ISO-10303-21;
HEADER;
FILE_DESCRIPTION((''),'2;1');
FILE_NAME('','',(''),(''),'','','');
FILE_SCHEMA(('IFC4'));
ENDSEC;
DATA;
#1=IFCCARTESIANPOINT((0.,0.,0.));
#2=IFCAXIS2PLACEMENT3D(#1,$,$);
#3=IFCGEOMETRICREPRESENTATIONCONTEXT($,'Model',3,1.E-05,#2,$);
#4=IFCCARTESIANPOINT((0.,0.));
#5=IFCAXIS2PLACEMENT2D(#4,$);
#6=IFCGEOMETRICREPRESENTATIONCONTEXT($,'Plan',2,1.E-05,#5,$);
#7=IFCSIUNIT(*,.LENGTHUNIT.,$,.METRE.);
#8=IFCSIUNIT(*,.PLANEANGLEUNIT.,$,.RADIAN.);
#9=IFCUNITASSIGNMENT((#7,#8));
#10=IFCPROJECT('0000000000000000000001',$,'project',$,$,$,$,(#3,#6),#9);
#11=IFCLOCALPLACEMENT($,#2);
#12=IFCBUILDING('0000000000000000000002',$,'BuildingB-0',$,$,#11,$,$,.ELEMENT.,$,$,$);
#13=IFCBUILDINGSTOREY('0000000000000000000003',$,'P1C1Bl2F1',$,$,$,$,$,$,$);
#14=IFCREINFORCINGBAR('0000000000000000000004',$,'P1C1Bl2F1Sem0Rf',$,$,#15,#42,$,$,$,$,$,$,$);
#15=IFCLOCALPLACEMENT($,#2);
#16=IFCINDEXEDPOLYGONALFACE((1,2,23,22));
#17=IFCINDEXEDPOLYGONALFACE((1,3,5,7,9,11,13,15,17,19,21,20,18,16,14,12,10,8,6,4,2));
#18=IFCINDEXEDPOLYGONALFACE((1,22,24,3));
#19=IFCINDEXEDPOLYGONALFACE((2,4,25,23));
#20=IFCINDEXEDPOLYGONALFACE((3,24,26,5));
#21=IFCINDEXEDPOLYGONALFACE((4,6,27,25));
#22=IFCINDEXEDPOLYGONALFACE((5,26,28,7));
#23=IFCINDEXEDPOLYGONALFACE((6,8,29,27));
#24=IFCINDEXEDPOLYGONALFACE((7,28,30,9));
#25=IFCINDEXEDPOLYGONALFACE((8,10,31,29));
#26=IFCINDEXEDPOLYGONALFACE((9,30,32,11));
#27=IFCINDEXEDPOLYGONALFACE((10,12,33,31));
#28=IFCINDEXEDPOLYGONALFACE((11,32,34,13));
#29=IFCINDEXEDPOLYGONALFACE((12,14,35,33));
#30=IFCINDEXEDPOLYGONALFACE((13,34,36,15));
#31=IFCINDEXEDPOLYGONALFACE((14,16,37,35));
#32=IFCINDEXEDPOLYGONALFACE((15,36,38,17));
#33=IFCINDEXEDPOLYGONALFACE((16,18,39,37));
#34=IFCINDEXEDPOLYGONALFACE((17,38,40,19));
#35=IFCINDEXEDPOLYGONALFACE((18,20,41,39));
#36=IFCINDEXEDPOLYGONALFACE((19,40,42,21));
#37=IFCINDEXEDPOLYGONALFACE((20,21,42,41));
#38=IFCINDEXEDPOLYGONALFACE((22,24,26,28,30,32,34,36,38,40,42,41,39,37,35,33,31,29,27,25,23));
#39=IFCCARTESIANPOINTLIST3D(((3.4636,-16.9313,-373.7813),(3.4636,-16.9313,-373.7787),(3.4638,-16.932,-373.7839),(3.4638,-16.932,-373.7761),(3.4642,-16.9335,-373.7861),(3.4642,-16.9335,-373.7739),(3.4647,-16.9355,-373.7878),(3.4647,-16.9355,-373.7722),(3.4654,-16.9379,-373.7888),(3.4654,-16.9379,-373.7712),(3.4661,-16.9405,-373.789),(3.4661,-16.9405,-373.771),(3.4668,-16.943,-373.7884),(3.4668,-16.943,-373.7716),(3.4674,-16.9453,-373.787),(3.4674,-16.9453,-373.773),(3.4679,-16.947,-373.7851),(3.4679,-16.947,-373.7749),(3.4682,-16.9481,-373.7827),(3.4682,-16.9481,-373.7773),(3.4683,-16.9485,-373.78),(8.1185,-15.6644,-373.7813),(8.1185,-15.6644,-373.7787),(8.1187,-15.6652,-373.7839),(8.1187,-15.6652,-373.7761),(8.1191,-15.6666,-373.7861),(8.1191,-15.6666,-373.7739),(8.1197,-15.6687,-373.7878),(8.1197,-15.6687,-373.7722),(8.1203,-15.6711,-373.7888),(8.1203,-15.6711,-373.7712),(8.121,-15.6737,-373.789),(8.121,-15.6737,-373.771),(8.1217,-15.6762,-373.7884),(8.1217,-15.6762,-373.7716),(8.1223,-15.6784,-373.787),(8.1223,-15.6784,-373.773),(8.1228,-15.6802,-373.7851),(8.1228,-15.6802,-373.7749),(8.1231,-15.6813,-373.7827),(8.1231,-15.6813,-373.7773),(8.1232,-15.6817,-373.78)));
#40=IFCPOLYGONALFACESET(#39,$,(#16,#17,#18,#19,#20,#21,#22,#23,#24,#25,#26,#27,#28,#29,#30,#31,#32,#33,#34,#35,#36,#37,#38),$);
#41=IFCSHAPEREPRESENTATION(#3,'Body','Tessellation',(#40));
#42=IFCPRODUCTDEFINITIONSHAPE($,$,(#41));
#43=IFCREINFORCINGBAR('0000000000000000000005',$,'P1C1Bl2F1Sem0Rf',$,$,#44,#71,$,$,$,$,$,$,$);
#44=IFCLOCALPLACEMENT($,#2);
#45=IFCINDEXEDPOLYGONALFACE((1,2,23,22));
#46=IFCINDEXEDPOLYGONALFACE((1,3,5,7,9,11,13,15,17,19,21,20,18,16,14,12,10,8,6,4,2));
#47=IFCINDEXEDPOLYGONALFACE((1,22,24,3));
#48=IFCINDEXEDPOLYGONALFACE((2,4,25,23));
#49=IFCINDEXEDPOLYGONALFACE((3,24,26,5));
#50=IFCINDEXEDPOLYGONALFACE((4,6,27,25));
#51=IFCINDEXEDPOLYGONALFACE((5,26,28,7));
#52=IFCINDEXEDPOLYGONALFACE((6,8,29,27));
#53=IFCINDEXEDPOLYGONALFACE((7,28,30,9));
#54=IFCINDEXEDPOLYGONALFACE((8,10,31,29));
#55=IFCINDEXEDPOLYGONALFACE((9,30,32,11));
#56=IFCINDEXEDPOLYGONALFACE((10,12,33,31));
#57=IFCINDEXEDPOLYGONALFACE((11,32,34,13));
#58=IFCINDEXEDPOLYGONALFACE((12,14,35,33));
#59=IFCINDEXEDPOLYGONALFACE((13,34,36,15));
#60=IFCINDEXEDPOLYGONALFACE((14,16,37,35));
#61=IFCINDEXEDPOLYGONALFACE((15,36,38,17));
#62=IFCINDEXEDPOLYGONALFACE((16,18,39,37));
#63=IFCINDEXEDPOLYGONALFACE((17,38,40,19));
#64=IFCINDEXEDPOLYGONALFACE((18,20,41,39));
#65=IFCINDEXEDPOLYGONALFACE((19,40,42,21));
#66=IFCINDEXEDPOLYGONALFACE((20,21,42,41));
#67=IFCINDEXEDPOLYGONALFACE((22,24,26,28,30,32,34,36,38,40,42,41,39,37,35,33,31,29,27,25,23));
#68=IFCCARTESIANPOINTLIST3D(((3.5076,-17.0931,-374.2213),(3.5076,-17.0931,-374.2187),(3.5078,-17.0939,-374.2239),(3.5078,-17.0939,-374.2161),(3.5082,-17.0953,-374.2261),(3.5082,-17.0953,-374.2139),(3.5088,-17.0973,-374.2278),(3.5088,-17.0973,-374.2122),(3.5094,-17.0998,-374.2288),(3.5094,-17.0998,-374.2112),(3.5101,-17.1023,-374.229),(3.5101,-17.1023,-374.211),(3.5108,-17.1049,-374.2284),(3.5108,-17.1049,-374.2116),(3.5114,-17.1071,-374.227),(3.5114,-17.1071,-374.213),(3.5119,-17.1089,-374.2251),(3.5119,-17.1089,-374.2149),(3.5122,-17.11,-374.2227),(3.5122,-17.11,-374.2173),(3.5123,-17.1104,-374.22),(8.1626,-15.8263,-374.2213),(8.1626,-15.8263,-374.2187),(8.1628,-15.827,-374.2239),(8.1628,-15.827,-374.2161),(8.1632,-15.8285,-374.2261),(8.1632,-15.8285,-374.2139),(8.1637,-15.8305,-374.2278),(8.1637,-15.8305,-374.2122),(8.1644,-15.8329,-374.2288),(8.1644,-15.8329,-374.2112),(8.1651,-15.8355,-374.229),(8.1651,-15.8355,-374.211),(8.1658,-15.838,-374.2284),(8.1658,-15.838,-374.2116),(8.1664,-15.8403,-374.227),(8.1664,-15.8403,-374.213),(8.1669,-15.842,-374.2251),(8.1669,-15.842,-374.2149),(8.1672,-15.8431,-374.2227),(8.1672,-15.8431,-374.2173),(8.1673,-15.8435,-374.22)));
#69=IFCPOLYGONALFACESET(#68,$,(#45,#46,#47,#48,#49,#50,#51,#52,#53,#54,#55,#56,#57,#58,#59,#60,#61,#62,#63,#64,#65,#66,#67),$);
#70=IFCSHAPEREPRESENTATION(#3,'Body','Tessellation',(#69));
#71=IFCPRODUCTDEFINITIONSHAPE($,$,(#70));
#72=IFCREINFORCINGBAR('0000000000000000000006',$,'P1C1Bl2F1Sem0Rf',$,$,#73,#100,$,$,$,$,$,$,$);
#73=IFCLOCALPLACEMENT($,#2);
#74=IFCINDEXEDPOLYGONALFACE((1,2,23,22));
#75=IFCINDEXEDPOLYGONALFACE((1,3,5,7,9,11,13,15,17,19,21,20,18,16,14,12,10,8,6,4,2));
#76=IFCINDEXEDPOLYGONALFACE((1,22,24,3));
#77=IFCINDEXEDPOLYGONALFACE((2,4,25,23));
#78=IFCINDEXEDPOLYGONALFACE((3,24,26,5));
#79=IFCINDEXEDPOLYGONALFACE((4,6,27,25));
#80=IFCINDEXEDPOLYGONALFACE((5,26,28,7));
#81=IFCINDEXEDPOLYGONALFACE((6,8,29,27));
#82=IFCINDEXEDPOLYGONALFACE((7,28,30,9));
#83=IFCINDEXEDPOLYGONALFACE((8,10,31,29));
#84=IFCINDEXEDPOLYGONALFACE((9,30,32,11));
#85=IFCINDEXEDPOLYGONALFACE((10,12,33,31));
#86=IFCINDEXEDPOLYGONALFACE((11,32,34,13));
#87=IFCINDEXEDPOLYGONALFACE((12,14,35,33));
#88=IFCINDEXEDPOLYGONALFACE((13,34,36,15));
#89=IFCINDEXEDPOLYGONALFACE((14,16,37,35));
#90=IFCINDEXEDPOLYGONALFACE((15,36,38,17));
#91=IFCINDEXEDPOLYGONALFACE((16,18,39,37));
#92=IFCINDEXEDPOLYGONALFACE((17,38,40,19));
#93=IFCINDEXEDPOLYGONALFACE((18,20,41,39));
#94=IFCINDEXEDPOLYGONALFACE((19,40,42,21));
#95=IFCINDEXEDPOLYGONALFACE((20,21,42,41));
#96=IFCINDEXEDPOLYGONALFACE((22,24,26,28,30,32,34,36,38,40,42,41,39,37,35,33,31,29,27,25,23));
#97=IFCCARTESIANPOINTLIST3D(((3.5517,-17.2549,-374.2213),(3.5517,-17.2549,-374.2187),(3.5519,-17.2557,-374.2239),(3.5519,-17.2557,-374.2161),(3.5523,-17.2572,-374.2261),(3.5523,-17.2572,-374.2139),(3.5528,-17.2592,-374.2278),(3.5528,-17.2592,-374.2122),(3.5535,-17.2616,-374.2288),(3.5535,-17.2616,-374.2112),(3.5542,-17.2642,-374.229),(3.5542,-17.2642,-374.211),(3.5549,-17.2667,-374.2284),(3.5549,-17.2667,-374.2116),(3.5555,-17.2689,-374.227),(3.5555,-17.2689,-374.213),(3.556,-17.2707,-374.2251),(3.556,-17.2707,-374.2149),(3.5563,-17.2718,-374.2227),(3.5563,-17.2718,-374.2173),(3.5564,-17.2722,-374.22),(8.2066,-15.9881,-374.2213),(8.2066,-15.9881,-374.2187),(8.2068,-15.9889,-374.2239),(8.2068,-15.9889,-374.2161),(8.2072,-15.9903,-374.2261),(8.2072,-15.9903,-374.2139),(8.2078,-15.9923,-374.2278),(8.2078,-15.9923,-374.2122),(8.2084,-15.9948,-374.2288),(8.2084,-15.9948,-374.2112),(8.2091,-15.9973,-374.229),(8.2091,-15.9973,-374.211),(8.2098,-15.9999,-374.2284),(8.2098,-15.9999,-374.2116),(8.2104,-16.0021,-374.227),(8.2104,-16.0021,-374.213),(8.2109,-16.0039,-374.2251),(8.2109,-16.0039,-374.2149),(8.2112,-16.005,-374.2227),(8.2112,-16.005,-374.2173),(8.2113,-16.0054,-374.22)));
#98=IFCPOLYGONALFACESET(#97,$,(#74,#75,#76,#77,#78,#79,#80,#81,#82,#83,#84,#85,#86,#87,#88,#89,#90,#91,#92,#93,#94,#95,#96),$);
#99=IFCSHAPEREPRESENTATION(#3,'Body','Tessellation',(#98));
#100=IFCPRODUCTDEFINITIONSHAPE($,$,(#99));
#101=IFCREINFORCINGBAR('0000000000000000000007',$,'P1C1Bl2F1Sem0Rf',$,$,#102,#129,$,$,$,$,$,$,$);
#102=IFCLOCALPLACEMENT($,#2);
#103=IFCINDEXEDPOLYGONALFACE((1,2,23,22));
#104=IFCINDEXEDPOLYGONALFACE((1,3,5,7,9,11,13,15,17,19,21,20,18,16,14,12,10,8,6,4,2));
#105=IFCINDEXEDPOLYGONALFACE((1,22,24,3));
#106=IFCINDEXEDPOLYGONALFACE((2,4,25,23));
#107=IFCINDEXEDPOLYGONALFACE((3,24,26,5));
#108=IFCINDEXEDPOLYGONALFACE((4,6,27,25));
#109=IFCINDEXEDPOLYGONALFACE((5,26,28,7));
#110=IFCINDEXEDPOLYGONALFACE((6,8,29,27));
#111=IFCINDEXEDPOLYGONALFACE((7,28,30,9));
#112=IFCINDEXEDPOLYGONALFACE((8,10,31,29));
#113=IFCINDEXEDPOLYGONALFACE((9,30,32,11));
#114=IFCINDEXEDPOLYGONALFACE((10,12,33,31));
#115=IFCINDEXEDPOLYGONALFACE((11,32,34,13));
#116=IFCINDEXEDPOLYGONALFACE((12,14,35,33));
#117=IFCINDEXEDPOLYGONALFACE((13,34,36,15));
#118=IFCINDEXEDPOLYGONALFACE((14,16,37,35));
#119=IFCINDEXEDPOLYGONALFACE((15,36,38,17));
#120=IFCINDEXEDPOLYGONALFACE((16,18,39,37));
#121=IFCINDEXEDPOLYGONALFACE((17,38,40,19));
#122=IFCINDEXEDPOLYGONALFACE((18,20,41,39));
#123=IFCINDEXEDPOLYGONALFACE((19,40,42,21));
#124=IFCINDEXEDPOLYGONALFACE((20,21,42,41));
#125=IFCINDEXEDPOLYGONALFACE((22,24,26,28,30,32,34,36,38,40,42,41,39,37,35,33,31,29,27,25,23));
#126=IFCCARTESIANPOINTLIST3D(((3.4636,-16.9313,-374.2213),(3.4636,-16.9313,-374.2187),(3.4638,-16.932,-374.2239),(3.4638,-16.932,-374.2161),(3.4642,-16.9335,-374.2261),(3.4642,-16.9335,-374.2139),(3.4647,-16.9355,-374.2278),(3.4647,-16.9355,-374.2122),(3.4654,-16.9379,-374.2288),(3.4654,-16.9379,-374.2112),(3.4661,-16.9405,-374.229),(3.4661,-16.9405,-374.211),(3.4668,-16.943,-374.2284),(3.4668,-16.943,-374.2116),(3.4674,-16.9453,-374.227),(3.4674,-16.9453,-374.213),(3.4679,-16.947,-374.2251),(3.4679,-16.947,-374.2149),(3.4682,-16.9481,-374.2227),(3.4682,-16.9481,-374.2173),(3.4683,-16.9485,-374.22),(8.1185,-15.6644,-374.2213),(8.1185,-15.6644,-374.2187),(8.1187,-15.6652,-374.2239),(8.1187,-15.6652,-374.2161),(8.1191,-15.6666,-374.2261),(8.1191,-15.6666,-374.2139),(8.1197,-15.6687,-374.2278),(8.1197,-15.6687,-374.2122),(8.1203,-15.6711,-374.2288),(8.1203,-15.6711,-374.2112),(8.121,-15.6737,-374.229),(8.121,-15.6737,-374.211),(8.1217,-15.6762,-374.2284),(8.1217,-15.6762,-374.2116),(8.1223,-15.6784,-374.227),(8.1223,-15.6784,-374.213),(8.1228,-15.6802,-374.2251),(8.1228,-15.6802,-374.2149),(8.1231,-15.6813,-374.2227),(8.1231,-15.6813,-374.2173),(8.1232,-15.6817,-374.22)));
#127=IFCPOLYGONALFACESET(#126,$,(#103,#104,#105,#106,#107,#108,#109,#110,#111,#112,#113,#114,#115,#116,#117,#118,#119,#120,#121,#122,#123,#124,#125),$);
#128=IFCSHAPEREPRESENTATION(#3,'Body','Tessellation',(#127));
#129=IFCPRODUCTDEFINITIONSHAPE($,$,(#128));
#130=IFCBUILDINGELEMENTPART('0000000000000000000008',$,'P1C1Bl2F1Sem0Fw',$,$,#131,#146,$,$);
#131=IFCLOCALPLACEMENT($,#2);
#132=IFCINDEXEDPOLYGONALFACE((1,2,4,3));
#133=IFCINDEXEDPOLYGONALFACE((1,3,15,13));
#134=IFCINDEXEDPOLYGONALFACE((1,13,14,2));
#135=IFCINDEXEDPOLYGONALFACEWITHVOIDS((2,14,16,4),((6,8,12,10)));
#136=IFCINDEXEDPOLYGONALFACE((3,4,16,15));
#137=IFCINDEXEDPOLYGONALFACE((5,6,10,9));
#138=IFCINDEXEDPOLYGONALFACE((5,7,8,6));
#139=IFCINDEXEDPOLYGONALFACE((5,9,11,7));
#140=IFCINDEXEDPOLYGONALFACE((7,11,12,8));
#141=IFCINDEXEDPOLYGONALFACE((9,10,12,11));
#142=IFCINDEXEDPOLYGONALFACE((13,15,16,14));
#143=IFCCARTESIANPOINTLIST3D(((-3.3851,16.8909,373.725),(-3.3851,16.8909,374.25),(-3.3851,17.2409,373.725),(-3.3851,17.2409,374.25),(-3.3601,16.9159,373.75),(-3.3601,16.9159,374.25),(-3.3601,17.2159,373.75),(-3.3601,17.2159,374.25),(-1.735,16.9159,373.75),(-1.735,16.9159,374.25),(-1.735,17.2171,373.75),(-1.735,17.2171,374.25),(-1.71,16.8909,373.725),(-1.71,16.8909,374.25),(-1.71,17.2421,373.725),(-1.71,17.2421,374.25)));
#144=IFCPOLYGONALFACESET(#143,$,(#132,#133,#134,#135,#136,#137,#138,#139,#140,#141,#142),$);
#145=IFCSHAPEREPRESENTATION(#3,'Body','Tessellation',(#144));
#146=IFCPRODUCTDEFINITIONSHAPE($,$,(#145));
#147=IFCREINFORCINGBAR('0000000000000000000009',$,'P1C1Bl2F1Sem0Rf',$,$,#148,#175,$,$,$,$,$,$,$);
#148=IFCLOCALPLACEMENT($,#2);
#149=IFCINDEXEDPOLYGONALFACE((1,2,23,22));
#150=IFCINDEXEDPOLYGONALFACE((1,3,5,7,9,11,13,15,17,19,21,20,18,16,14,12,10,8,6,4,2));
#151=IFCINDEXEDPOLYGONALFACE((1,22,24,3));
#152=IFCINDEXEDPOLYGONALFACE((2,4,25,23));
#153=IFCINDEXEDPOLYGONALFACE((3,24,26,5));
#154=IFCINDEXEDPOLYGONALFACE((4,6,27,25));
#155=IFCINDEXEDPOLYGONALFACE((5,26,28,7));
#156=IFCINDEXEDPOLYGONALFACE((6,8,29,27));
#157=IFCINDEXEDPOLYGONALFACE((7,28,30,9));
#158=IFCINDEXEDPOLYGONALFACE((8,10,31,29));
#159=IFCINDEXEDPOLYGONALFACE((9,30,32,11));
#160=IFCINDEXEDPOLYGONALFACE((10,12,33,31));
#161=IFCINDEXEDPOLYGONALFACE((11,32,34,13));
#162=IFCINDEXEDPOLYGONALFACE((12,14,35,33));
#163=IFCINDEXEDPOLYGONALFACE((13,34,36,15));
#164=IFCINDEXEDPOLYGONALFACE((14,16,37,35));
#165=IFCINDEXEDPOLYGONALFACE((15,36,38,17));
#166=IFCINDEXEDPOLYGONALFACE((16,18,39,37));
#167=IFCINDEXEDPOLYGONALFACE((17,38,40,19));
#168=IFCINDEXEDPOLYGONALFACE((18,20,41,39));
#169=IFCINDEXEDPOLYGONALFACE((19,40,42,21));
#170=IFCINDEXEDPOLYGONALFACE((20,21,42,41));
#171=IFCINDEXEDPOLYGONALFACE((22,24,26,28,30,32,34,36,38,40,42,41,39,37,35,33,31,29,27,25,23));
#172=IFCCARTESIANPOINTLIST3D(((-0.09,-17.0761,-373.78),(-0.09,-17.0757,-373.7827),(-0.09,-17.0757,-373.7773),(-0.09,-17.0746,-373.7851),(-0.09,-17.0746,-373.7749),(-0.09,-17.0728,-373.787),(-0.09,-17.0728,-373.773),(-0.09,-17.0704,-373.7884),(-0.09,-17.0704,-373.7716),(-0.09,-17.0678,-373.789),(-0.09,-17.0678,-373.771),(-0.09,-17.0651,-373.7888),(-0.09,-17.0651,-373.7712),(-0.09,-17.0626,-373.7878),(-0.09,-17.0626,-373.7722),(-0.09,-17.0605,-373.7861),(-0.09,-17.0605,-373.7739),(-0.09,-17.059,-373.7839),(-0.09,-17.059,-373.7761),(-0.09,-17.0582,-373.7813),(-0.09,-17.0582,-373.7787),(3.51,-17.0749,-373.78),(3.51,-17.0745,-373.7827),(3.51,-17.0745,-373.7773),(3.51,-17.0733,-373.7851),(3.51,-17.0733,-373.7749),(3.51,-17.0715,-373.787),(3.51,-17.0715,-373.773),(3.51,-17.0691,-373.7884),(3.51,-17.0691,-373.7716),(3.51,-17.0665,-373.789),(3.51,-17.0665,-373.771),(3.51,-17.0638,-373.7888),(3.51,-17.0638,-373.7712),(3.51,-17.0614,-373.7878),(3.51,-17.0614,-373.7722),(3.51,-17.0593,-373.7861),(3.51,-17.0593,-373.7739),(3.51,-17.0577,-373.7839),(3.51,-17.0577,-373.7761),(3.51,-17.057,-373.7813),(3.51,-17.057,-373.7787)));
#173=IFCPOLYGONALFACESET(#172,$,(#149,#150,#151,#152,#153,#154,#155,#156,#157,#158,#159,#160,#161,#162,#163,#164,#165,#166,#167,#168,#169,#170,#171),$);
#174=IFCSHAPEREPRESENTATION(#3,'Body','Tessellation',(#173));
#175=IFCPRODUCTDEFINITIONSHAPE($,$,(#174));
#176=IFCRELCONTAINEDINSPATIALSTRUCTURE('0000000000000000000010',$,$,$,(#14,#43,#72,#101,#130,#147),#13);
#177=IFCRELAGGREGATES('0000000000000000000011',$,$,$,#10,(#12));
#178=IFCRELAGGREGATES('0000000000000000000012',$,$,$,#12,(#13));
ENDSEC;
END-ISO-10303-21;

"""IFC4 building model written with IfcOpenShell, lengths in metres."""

from ifc_helpers import new_model, entity, si_unit, origin, origin_2d, place, context, project, spatial, polyline, outline, extrude, element, save


model = new_model("IFC4")

# Units and contexts
model_context = context("Model", 3, precision=1e-05, world=origin())
plan_context = context("Plan", 2, precision=1e-05, world=origin_2d())
ifc_project = project(units=[si_unit("LENGTHUNIT", "METRE"), si_unit("PLANEANGLEUNIT", "RADIAN")], contexts=[model_context, plan_context])

# Building, storey
building_placement = place(None, origin())
building = spatial("IfcBuilding", under=ifc_project, at=building_placement, Name="BuildingB-0", CompositionType="ELEMENT")
storey = spatial("IfcBuildingStorey", under=building, Name="P1C1Bl2F1")

# Reinforcing bars
element("IfcReinforcingBar", 1, inside=storey, Name="P1C1Bl2F1Sem0Rf", context=model_context, shape_type="SweptSolid", body=[
    entity("IfcSurfaceCurveSweptAreaSolid", entity("IfcCircleProfileDef", "AREA", None, None, 0.009), None, entity("IfcPolyline", [entity("IfcCartesianPoint", [-3.4659, 16.9398, 373.78]), entity("IfcCartesianPoint", [-8.1209, 15.673, 373.78])]), None, None, entity("IfcPlane", entity("IfcAxis2Placement3D", entity("IfcCartesianPoint", [-3.4659, 16.9398, 373.78]), entity("IfcDirection", [0.0, 0.0, 1.0]), entity("IfcDirection", [1.0, 0.0, 0.0])))),
])
element("IfcReinforcingBar", 2, inside=storey, Name="P1C1Bl2F1Sem0Rf", context=model_context, shape_type="SweptSolid", body=[
    entity("IfcSurfaceCurveSweptAreaSolid", entity("IfcCircleProfileDef", "AREA", None, None, 0.009), None, entity("IfcPolyline", [entity("IfcCartesianPoint", [-3.51, 17.1017, 374.22]), entity("IfcCartesianPoint", [-8.1649, 15.8348, 374.22])]), None, None, entity("IfcPlane", entity("IfcAxis2Placement3D", entity("IfcCartesianPoint", [-3.51, 17.1017, 374.22]), entity("IfcDirection", [0.0, 0.0, 1.0]), entity("IfcDirection", [1.0, 0.0, 0.0])))),
])
element("IfcReinforcingBar", 3, inside=storey, Name="P1C1Bl2F1Sem0Rf", context=model_context, shape_type="SweptSolid", body=[
    entity("IfcSurfaceCurveSweptAreaSolid", entity("IfcCircleProfileDef", "AREA", None, None, 0.009), None, entity("IfcPolyline", [entity("IfcCartesianPoint", [-3.554, 17.2635, 374.22]), entity("IfcCartesianPoint", [-8.209, 15.9967, 374.22])]), None, None, entity("IfcPlane", entity("IfcAxis2Placement3D", entity("IfcCartesianPoint", [-3.554, 17.2635, 374.22]), entity("IfcDirection", [0.0, 0.0, 1.0]), entity("IfcDirection", [1.0, 0.0, 0.0])))),
])
element("IfcReinforcingBar", 4, inside=storey, Name="P1C1Bl2F1Sem0Rf", context=model_context, shape_type="SweptSolid", body=[
    entity("IfcSurfaceCurveSweptAreaSolid", entity("IfcCircleProfileDef", "AREA", None, None, 0.009), None, entity("IfcPolyline", [entity("IfcCartesianPoint", [-3.4659, 16.9398, 374.22]), entity("IfcCartesianPoint", [-8.1209, 15.673, 374.22])]), None, None, entity("IfcPlane", entity("IfcAxis2Placement3D", entity("IfcCartesianPoint", [-3.4659, 16.9398, 374.22]), entity("IfcDirection", [0.0, 0.0, 1.0]), entity("IfcDirection", [1.0, 0.0, 0.0])))),
])

# Building element part, opening
building_element_part_1 = element("IfcBuildingElementPart", 5, inside=storey, Name="P1C1Bl2F1Sem0Fw", context=model_context, shape_type="SweptSolid", body=[
    extrude(outline(polyline([(-3.3851, 17.2409, 373.725), (-3.3851, 16.8909, 373.725), (-1.71, 16.8909, 373.725), (-1.71, 17.2421, 373.725), (-3.3851, 17.2409, 373.725)])), None, (0.0, 0.0, 1.0), 0.525),
])
element("IfcOpeningElement", 6, inside=storey, cuts=building_element_part_1, context=model_context, shape_type="SweptSolid", body=[
    extrude(outline(polyline([(-3.3601, 17.2159, 373.75), (-3.3601, 16.9159, 373.75), (-1.735, 16.9159, 373.75), (-1.735, 17.2171, 373.75), (-3.3601, 17.2159, 373.75)])), None, (0.0, 0.0, 1.0), 0.5),
])

# Reinforcing bar
element("IfcReinforcingBar", 7, inside=storey, Name="P1C1Bl2F1Sem0Rf", context=model_context, shape_type="SweptSolid", body=[
    entity("IfcSurfaceCurveSweptAreaSolid", entity("IfcCircleProfileDef", "AREA", None, None, 0.009), None, entity("IfcPolyline", [entity("IfcCartesianPoint", [0.09, 17.0671, 373.78]), entity("IfcCartesianPoint", [-3.51, 17.0659, 373.78])]), None, None, entity("IfcPlane", entity("IfcAxis2Placement3D", entity("IfcCartesianPoint", [0.09, 17.0671, 373.78]), entity("IfcDirection", [0.0, 0.0, 1.0]), entity("IfcDirection", [1.0, 0.0, 0.0])))),
])

save(model, "model.ifc")
